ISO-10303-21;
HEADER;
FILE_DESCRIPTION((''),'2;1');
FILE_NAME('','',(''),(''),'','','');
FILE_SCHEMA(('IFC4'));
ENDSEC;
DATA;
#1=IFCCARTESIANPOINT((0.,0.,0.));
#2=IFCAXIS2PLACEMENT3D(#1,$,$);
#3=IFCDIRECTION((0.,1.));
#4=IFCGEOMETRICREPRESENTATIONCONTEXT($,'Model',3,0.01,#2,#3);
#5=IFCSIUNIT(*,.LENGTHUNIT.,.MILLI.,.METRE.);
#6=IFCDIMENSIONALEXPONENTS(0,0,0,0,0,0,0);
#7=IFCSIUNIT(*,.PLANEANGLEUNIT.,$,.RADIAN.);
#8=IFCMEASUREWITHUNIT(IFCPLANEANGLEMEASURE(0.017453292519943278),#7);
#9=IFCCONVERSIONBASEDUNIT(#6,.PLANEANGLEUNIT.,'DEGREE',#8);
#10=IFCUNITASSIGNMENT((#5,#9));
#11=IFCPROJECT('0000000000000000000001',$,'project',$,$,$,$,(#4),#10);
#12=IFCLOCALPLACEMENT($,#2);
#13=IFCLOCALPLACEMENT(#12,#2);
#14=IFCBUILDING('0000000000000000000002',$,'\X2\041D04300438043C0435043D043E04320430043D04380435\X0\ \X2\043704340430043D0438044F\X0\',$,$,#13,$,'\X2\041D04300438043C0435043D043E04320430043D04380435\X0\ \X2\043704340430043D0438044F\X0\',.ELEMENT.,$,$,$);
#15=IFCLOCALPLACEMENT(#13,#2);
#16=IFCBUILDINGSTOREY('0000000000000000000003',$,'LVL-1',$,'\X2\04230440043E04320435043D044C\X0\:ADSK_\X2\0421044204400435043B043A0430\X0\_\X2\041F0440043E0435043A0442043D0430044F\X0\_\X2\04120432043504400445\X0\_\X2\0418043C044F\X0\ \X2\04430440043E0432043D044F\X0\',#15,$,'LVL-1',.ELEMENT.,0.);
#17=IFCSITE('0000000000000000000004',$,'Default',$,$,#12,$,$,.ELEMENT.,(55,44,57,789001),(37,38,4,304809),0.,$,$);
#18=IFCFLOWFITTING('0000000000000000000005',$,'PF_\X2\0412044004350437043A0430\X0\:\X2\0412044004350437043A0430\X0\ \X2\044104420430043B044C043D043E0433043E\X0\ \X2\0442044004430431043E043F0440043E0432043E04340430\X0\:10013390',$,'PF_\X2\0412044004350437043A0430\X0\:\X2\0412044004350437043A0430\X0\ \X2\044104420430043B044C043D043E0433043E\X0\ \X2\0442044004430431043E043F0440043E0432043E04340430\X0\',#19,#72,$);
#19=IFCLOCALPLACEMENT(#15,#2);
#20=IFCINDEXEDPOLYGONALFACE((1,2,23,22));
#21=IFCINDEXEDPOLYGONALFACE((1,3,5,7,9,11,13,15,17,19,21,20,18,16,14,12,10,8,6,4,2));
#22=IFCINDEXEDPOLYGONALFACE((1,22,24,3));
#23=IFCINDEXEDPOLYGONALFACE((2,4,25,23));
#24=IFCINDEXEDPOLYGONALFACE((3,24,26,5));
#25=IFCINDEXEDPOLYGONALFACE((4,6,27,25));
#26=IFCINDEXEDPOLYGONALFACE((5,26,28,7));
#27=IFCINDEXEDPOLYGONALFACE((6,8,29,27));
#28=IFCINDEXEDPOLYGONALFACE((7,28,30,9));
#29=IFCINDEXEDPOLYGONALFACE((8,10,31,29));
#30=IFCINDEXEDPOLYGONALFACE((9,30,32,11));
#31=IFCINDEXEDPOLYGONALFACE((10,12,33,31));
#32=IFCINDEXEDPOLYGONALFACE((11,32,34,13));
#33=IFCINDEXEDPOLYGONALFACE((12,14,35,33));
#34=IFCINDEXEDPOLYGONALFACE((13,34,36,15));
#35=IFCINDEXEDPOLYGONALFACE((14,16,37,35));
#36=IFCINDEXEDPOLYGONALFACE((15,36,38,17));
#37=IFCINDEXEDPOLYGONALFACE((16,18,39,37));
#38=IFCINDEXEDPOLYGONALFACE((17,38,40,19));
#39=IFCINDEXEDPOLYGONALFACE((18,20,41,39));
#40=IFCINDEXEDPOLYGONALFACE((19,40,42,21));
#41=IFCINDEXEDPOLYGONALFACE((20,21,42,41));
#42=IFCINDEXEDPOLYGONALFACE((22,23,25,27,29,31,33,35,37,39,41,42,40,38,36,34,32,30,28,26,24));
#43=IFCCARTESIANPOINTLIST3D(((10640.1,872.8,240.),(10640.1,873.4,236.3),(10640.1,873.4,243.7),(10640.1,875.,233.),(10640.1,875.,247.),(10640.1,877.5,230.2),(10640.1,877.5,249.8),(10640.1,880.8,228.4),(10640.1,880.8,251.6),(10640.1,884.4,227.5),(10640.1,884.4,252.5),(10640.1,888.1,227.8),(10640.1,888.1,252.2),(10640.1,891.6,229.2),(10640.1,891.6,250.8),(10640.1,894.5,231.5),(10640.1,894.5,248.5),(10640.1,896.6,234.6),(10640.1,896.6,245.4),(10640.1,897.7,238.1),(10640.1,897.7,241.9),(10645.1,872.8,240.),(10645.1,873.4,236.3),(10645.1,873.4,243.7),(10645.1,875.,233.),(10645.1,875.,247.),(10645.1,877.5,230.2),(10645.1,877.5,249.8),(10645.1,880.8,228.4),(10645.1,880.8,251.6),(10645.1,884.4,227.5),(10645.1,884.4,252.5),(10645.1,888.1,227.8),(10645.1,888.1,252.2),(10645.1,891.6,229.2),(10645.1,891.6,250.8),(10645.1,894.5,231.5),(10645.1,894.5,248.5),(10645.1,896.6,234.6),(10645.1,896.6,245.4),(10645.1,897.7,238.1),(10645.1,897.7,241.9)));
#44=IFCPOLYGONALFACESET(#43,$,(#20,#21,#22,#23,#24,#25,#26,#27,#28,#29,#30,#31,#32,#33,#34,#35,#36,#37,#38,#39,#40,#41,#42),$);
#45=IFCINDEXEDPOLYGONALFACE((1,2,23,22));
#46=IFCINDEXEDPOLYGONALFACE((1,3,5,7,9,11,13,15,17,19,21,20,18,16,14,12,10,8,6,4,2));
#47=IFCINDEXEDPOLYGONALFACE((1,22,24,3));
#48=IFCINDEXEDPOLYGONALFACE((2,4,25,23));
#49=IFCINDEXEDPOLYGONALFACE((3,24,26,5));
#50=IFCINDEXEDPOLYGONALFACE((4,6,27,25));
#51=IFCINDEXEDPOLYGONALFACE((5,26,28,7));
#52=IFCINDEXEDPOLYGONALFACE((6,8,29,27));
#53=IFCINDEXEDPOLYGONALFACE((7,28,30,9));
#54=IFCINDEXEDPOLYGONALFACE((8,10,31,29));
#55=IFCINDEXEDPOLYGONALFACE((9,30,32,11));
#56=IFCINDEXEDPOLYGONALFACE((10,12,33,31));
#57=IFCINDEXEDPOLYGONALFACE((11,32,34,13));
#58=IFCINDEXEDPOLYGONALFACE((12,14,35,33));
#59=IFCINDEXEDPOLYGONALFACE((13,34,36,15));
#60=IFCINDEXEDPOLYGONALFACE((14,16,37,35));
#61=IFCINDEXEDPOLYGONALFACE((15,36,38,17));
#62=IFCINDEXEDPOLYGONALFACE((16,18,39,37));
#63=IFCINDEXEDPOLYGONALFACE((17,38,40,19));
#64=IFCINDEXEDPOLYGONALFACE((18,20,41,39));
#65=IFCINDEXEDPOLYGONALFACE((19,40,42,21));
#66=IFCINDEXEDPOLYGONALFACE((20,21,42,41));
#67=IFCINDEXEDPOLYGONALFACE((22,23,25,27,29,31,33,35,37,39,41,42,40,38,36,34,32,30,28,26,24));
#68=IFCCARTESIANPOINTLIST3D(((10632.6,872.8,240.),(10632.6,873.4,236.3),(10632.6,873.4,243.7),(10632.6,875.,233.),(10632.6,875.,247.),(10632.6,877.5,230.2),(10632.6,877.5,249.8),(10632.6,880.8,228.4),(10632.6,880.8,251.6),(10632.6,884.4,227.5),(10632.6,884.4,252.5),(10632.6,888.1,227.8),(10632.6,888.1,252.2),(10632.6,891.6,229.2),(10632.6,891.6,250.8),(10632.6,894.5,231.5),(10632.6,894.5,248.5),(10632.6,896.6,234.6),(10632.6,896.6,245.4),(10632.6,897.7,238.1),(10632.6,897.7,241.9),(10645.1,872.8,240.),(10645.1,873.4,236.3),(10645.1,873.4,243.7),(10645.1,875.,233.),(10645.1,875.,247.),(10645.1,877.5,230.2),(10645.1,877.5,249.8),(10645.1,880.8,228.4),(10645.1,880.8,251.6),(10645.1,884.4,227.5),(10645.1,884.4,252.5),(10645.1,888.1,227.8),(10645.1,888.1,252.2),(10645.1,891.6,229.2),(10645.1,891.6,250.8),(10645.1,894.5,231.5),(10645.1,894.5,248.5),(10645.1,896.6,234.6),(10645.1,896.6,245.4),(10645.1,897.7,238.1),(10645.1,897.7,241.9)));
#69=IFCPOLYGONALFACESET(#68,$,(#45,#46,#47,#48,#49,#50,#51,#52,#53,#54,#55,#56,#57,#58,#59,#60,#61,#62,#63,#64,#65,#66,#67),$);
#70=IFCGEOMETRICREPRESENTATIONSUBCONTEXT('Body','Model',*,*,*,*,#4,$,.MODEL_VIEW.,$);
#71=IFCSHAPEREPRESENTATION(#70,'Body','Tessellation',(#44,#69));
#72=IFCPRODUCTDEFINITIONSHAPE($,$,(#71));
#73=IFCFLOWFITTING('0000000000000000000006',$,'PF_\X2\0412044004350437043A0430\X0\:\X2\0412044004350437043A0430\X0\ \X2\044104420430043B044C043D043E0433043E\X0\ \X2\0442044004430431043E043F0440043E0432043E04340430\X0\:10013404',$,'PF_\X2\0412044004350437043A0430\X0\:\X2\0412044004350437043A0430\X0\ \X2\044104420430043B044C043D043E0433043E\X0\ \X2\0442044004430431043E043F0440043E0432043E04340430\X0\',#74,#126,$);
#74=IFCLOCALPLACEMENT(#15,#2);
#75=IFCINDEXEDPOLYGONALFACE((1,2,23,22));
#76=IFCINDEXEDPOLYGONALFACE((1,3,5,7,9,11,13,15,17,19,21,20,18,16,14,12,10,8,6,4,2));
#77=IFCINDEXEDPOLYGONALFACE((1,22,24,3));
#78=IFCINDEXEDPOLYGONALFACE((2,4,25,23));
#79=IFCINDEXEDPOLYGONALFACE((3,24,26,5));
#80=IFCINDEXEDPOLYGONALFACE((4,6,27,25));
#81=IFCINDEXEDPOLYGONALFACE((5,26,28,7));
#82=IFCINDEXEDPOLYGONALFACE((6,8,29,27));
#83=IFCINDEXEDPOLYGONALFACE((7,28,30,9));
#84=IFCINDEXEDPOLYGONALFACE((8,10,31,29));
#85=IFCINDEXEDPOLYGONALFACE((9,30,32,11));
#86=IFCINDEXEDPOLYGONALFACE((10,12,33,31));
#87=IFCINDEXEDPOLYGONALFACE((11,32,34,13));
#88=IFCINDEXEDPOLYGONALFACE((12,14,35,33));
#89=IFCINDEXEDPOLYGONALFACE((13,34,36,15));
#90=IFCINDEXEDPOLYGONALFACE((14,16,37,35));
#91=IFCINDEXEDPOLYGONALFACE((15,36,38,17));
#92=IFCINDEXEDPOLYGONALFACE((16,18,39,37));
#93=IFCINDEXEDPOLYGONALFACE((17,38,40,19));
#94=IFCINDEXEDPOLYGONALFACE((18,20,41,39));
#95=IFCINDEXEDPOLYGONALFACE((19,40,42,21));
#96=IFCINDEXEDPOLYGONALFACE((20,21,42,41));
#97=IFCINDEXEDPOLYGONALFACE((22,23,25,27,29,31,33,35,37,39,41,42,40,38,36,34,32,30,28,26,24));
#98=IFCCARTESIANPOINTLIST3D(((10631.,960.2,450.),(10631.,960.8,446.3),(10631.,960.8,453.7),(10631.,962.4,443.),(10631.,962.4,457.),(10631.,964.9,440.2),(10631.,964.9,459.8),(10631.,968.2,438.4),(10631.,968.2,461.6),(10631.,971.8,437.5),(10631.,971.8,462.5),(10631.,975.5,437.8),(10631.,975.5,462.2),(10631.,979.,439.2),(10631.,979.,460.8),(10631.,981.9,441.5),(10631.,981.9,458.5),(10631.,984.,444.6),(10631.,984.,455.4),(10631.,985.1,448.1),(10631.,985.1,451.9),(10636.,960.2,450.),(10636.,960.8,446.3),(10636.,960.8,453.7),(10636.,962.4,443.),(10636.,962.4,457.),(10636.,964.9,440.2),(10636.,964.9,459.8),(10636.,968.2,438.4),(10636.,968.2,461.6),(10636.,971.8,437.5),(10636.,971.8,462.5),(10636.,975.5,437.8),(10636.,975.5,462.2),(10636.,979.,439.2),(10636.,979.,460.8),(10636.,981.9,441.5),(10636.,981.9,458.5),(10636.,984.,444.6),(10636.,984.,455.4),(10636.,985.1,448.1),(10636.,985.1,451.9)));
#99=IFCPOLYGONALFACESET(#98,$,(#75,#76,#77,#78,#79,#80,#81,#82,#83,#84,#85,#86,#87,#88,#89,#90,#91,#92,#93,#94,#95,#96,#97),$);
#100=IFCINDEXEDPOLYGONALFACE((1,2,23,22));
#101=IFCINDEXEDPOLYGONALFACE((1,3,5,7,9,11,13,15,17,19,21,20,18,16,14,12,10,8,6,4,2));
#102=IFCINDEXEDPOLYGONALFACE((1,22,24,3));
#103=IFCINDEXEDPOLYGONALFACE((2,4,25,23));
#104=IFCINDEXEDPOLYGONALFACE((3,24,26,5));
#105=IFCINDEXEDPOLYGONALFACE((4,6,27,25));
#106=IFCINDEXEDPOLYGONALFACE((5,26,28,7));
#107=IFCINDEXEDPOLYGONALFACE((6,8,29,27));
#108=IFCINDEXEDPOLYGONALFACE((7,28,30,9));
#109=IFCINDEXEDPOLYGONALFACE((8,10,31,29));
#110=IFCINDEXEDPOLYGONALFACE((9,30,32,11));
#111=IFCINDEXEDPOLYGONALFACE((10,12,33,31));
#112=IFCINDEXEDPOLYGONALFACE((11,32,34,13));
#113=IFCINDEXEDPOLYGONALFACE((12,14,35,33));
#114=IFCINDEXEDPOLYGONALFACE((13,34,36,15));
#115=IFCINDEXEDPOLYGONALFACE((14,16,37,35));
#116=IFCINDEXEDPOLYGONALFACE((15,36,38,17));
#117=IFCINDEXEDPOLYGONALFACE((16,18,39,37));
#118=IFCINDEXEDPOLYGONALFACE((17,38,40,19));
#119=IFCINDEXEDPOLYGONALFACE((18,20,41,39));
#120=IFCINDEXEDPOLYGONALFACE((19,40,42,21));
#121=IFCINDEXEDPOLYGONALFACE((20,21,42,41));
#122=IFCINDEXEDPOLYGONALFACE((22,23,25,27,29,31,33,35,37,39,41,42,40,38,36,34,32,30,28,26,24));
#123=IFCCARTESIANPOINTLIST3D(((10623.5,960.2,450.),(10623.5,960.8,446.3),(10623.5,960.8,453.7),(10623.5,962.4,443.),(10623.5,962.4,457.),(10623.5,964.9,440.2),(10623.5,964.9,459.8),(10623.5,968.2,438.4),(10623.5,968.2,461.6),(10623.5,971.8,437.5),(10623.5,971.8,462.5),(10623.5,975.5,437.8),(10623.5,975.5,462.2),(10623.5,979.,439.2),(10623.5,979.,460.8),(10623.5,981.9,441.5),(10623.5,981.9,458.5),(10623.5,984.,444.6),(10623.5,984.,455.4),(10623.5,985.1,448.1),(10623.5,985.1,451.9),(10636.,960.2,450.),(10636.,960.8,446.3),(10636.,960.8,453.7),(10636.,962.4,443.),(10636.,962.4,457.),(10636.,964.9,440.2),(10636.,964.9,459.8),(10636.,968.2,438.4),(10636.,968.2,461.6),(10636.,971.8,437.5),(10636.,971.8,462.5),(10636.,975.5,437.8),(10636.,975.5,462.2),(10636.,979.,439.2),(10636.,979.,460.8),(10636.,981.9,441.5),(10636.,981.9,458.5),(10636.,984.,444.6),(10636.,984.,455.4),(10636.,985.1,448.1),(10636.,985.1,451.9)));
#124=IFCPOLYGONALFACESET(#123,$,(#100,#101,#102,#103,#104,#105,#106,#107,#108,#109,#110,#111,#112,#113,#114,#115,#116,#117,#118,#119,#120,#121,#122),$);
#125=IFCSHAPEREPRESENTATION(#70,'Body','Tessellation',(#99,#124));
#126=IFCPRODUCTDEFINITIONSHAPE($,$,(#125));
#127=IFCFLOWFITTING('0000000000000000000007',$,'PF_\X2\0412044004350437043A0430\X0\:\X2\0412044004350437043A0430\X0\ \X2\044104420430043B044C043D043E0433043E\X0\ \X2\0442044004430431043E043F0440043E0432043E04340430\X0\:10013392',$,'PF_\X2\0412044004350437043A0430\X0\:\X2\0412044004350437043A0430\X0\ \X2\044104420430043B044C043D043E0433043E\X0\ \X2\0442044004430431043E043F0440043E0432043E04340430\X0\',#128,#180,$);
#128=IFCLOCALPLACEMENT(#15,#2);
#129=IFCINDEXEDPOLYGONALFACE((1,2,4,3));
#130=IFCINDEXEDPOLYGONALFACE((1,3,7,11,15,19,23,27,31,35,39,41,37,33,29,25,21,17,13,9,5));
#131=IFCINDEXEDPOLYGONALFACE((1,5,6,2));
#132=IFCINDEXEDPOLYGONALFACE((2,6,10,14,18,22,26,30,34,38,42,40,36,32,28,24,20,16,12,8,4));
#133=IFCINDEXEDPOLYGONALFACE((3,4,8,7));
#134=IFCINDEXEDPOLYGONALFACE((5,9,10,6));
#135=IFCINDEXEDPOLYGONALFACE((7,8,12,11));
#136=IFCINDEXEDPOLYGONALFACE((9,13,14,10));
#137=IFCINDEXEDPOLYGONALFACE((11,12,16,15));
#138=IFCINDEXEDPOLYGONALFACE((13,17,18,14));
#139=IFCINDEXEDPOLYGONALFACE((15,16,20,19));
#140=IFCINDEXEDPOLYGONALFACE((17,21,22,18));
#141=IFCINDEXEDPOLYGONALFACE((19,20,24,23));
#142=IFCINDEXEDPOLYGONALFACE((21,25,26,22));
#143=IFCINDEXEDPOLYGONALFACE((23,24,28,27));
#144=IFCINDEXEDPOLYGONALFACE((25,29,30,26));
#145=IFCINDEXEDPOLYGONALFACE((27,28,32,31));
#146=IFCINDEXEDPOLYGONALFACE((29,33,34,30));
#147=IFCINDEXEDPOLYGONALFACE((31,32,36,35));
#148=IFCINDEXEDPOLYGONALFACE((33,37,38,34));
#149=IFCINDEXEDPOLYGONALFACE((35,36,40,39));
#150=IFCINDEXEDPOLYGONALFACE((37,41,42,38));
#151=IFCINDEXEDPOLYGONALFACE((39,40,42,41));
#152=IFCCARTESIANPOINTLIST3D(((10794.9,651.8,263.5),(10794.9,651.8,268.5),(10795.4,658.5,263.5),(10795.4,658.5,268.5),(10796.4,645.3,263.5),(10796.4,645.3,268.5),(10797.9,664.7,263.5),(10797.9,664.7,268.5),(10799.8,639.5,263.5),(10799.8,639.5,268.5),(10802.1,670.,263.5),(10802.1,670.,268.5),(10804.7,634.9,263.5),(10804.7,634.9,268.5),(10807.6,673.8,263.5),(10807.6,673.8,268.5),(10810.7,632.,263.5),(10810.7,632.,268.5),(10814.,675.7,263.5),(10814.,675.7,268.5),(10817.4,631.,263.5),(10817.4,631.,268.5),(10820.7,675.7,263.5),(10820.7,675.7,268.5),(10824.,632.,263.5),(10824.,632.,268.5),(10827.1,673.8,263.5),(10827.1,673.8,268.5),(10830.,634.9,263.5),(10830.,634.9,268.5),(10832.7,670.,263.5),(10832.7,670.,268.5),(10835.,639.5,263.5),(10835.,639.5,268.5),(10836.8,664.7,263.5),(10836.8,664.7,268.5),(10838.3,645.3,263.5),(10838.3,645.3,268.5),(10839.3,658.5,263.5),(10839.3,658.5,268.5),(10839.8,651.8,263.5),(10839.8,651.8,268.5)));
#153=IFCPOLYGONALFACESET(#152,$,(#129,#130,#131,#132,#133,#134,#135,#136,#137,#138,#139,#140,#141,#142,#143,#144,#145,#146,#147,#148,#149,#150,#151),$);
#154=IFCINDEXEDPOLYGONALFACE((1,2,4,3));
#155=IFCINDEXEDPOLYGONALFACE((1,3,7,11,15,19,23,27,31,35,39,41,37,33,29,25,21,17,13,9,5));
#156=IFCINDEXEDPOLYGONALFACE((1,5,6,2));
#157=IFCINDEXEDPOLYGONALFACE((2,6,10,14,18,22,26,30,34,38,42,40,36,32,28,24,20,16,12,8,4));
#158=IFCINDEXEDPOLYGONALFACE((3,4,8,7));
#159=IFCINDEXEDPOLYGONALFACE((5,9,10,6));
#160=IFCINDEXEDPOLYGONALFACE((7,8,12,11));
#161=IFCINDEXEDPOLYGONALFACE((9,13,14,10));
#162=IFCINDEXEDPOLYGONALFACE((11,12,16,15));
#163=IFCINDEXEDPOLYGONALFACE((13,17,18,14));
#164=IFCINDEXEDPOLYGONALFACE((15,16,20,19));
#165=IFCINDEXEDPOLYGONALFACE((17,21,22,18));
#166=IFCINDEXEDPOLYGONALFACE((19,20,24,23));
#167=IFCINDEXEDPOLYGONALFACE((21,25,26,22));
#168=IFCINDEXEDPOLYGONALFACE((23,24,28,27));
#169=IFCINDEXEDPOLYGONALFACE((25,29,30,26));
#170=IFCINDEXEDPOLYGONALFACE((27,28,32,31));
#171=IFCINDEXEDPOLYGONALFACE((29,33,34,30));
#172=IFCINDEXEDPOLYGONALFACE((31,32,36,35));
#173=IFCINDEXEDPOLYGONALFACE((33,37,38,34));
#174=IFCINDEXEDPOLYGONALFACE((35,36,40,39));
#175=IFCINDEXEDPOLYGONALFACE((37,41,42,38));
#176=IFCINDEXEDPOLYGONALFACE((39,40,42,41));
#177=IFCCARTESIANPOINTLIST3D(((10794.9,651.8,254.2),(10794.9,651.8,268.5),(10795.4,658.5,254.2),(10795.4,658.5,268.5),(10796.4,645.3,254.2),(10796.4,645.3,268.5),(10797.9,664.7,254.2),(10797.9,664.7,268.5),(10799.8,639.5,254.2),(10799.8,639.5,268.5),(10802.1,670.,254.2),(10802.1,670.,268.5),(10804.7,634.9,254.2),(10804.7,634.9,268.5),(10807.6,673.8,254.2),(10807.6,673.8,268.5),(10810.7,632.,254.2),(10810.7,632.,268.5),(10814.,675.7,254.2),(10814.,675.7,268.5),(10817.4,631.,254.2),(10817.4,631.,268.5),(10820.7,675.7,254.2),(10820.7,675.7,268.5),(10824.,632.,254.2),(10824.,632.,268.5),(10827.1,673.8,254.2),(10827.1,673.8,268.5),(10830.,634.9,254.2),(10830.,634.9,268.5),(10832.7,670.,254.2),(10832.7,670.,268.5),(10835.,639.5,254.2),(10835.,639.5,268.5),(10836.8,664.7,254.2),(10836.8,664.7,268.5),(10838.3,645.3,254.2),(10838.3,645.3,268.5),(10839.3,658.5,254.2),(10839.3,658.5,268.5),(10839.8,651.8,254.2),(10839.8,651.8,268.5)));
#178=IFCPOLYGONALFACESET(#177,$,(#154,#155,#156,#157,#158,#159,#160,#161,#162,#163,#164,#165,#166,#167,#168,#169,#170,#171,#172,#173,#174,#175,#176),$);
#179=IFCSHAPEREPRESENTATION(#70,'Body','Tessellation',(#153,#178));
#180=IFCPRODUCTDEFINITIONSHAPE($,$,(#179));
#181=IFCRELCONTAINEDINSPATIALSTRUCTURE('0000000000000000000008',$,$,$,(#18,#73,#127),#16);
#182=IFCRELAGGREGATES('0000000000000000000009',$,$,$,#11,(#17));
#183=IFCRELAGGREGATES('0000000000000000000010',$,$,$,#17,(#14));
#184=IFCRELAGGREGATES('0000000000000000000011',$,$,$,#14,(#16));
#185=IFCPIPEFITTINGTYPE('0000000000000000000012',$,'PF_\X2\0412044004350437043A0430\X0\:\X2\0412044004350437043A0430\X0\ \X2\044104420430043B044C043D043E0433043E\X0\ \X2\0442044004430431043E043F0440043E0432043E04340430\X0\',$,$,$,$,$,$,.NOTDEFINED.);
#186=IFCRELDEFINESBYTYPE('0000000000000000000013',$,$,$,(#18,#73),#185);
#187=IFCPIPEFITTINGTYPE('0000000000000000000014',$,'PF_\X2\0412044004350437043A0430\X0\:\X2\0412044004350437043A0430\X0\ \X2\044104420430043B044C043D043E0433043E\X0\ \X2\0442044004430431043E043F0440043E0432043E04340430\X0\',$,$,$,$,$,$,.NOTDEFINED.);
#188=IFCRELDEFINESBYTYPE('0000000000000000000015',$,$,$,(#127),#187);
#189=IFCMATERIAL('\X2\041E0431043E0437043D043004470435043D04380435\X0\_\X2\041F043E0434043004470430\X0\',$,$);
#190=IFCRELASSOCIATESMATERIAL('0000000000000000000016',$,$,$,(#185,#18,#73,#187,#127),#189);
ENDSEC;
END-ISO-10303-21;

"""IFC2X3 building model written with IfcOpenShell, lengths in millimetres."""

from ifc_helpers import new_model, entity, si_unit, converted_unit, direction, frame, frame_2d, origin, place, context, subcontext, project, spatial, circle, extrude, source, transform, mapped, material, type_object, type_shapes, element, save


model = new_model("IFC2X3")

# Units and contexts
model_context = context("Model", 3, precision=0.01, world=origin(), true_north=direction((0.0, 1.0)))
body_context = subcontext(model_context, "Body", "Model", "MODEL_VIEW")
ifc_project = project(units=[si_unit("LENGTHUNIT", "METRE", prefix="MILLI"), converted_unit("PLANEANGLEUNIT", "DEGREE", entity("IfcPlaneAngleMeasure", 0.017453292519943278), si_unit("PLANEANGLEUNIT", "RADIAN"), dimensions=[0, 0, 0, 0, 0, 0, 0])], contexts=[model_context])

# Site, building, storey
site_placement = place(None, origin())
site = spatial("IfcSite", under=ifc_project, at=site_placement, Name="Default", CompositionType="ELEMENT", RefLatitude=(55, 44, 57, 789001), RefLongitude=(37, 38, 4, 304809), RefElevation=0.0)
building_placement = place(site_placement, origin())
building = spatial("IfcBuilding", under=site, at=building_placement, Name="Наименование здания", LongName="Наименование здания", CompositionType="ELEMENT")
storey_placement = place(building_placement, origin())
storey = spatial("IfcBuildingStorey", under=building, at=storey_placement, Name="LVL-1", ObjectType="Уровень:ADSK_Стрелка_Проектная_Вверх_Имя уровня", LongName="LVL-1", CompositionType="ELEMENT", Elevation=0.0)

# Shared definitions
ifc_material_1 = material(Name="Обозначение_Подача")

# Flow fittings
pipe_fitting_type_1 = type_object("IfcPipeFittingType", Name="PF_Врезка:Врезка стального трубопровода", PredefinedType="NOTDEFINED", material=ifc_material_1)
shared_shape_1 = source(origin(), body_context, "Body", "SweptSolid", [
    extrude(circle(Radius=12.5, at=frame_2d((0.0, 0.0), x_axis=(1.0, 0.0))), frame((-5.0, 0.0, 0.0), z_axis=(1.0, 0.0, 0.0), x_axis=(0.0, 1.0, 0.0)), (0.0, 0.0, 1.0), 5.0),
    extrude(circle(Radius=12.5, at=frame_2d((0.0, 0.0), x_axis=(1.0, 0.0))), frame((-12.5, 0.0, 0.0), z_axis=(1.0, 0.0, 0.0), x_axis=(0.0, 1.0, 0.0)), (0.0, 0.0, 1.0), 12.5),
])
type_shapes(pipe_fitting_type_1, [shared_shape_1])
for number, where, z_axis, x_axis, name in (
    (1, (10645.1, 885.3, 240.0), (0.0, 0.0, -1.0), (1.0, 0.0, 0.0), "PF_Врезка:Врезка стального трубопровода:10013390"),
    (2, (10636.0, 972.7, 450.0), (0.0, 0.0, -1.0), (1.0, 0.0, 0.0), "PF_Врезка:Врезка стального трубопровода:10013404"),
):
    element("IfcFlowFitting", number, at=place(storey_placement, frame(where, z_axis=z_axis, x_axis=x_axis)), inside=storey, type_object=pipe_fitting_type_1, material=ifc_material_1, Name=name, ObjectType="PF_Врезка:Врезка стального трубопровода", context=body_context, shape_type="MappedRepresentation", body=[
        mapped(shared_shape_1, transform((0.0, 0.0, 0.0), scale=1.0)),
    ])
pipe_fitting_type_2 = type_object("IfcPipeFittingType", Name="PF_Врезка:Врезка стального трубопровода", PredefinedType="NOTDEFINED", material=ifc_material_1)
shared_shape_2 = source(origin(), body_context, "Body", "SweptSolid", [
    extrude(circle(Radius=22.5, at=frame_2d((0.0, 0.0), x_axis=(1.0, 0.0))), frame((-5.0, 0.0, 0.0), z_axis=(1.0, 0.0, 0.0), x_axis=(0.0, 1.0, 0.0)), (0.0, 0.0, 1.0), 5.0),
    extrude(circle(Radius=22.5, at=frame_2d((0.0, 0.0), x_axis=(1.0, 0.0))), frame((-14.3, 0.0, 0.0), z_axis=(1.0, 0.0, 0.0), x_axis=(0.0, 1.0, 0.0)), (0.0, 0.0, 1.0), 14.3),
])
type_shapes(pipe_fitting_type_2, [shared_shape_2])
flow_fitting_1_placement = place(storey_placement, frame((10817.4, 653.5, 268.5), z_axis=(1.0, 0.0, 0.0), x_axis=(0.0, 0.0, 1.0)))
element("IfcFlowFitting", 3, at=flow_fitting_1_placement, inside=storey, type_object=pipe_fitting_type_2, material=ifc_material_1, Name="PF_Врезка:Врезка стального трубопровода:10013392", ObjectType="PF_Врезка:Врезка стального трубопровода", context=body_context, shape_type="MappedRepresentation", body=[
    mapped(shared_shape_2, transform((0.0, 0.0, 0.0), scale=1.0)),
])

save(model, "model.ifc")
